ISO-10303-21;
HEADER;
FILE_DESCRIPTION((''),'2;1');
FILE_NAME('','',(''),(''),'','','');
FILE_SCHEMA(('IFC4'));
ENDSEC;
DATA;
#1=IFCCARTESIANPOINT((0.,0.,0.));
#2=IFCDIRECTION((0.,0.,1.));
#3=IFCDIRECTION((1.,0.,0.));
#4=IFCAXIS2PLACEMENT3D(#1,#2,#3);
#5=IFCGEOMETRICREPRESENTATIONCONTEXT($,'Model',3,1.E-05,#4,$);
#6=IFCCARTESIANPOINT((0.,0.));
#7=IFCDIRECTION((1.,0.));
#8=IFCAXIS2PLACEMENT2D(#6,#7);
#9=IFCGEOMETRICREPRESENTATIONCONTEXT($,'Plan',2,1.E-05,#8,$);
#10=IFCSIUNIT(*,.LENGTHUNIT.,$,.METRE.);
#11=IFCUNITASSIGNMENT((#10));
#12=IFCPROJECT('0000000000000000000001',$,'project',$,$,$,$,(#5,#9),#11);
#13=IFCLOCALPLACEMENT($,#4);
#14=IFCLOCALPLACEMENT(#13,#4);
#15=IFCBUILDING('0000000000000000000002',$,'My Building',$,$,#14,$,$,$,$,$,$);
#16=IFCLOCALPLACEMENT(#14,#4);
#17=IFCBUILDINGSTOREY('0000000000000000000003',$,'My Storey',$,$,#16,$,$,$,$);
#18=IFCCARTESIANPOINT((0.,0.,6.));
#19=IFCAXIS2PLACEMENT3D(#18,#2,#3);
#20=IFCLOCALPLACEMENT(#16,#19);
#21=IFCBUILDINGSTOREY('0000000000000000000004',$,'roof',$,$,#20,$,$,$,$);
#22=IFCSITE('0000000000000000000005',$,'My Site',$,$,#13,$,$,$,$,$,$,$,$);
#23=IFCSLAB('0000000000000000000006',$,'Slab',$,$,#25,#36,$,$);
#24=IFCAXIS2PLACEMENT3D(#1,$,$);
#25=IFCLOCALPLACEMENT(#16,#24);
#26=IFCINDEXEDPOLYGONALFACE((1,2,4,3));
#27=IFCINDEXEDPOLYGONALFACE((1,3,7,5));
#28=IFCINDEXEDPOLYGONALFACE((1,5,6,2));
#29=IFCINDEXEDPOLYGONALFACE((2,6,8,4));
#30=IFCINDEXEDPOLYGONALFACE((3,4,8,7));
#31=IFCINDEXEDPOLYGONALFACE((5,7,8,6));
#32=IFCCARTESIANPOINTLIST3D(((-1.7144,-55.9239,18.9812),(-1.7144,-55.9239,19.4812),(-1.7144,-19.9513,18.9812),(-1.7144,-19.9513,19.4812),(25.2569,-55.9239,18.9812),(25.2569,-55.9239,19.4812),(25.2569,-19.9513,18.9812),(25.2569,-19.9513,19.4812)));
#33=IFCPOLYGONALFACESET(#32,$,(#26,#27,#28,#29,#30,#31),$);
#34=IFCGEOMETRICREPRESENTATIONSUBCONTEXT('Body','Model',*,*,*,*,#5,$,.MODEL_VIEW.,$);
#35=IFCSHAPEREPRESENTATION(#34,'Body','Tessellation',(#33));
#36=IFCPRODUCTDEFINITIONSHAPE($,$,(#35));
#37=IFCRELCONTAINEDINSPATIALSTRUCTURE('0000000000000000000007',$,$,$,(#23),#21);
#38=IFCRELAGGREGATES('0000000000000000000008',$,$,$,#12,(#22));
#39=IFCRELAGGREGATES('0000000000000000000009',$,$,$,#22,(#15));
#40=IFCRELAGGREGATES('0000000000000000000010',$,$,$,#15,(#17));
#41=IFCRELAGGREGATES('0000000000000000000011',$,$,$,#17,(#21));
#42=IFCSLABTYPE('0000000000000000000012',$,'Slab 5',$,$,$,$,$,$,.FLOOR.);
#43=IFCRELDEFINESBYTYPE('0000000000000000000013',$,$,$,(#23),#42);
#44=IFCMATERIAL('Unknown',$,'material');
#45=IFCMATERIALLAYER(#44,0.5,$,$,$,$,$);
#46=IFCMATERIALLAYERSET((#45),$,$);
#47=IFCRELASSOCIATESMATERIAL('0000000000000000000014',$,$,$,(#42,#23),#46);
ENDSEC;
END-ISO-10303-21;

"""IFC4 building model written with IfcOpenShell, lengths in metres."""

from ifc_helpers import new_model, si_unit, frame, origin_with_axes, origin_2d_with_axis, place, context, subcontext, project, spatial, indexed_curve, outline, extrude, material, layer, layer_set, layer_usage, type_object, element, save


model = new_model("IFC4")

# Units and contexts
model_context = context("Model", 3, precision=1e-05, world=origin_with_axes())
plan_context = context("Plan", 2, precision=1e-05, world=origin_2d_with_axis())
body_context = subcontext(model_context, "Body", "Model", "MODEL_VIEW")
ifc_project = project(units=[si_unit("LENGTHUNIT", "METRE")], contexts=[model_context, plan_context])

# Site, building, storeys
site_placement = place(None, origin_with_axes())
site = spatial("IfcSite", under=ifc_project, at=site_placement, Name="My Site")
building_placement = place(site_placement, origin_with_axes())
building = spatial("IfcBuilding", under=site, at=building_placement, Name="My Building")
storey_1_placement = place(building_placement, origin_with_axes())
storey_1 = spatial("IfcBuildingStorey", under=building, at=storey_1_placement, Name="My Storey")
storey_2_placement = place(storey_1_placement, frame((0.0, 0.0, 6.0), z_axis=(0.0, 0.0, 1.0), x_axis=(1.0, 0.0, 0.0)))
storey_2 = spatial("IfcBuildingStorey", under=storey_1, at=storey_2_placement, Name="roof")

# Slab
ifc_material = material(Name="Unknown", Category="material")
ifc_layer = layer(ifc_material, 0.5)
ifc_layer_set = layer_set([ifc_layer])
ifc_layer_usage = layer_usage(ifc_layer_set, "AXIS3", "POSITIVE", -0.5)
slab_type = type_object("IfcSlabType", Name="Slab 5", PredefinedType="FLOOR", material=ifc_layer_set)
slab_placement = place(storey_2_placement, frame((-1.7144, -19.9513, 13.4812), z_axis=(0.0, 0.0, 1.0), x_axis=(1.0, 0.0, 0.0)))
element("IfcSlab", 1, at=slab_placement, inside=storey_2, type_object=slab_type, material=ifc_layer_usage, Name="Slab", context=body_context, shape_type="SweptSolid", body=[
    extrude(outline(indexed_curve([(0.0, 0.0), (0.0, -35.9726), (26.9713, -35.9726), (26.9713, 0.0), (0.0, 0.0)])), frame((0.0, 0.0, -0.5), z_axis=(0.0, 0.0, 1.0), x_axis=(1.0, 0.0, 0.0)), (0.0, 0.0, 1.0), 0.5),
])

save(model, "model.ifc")
